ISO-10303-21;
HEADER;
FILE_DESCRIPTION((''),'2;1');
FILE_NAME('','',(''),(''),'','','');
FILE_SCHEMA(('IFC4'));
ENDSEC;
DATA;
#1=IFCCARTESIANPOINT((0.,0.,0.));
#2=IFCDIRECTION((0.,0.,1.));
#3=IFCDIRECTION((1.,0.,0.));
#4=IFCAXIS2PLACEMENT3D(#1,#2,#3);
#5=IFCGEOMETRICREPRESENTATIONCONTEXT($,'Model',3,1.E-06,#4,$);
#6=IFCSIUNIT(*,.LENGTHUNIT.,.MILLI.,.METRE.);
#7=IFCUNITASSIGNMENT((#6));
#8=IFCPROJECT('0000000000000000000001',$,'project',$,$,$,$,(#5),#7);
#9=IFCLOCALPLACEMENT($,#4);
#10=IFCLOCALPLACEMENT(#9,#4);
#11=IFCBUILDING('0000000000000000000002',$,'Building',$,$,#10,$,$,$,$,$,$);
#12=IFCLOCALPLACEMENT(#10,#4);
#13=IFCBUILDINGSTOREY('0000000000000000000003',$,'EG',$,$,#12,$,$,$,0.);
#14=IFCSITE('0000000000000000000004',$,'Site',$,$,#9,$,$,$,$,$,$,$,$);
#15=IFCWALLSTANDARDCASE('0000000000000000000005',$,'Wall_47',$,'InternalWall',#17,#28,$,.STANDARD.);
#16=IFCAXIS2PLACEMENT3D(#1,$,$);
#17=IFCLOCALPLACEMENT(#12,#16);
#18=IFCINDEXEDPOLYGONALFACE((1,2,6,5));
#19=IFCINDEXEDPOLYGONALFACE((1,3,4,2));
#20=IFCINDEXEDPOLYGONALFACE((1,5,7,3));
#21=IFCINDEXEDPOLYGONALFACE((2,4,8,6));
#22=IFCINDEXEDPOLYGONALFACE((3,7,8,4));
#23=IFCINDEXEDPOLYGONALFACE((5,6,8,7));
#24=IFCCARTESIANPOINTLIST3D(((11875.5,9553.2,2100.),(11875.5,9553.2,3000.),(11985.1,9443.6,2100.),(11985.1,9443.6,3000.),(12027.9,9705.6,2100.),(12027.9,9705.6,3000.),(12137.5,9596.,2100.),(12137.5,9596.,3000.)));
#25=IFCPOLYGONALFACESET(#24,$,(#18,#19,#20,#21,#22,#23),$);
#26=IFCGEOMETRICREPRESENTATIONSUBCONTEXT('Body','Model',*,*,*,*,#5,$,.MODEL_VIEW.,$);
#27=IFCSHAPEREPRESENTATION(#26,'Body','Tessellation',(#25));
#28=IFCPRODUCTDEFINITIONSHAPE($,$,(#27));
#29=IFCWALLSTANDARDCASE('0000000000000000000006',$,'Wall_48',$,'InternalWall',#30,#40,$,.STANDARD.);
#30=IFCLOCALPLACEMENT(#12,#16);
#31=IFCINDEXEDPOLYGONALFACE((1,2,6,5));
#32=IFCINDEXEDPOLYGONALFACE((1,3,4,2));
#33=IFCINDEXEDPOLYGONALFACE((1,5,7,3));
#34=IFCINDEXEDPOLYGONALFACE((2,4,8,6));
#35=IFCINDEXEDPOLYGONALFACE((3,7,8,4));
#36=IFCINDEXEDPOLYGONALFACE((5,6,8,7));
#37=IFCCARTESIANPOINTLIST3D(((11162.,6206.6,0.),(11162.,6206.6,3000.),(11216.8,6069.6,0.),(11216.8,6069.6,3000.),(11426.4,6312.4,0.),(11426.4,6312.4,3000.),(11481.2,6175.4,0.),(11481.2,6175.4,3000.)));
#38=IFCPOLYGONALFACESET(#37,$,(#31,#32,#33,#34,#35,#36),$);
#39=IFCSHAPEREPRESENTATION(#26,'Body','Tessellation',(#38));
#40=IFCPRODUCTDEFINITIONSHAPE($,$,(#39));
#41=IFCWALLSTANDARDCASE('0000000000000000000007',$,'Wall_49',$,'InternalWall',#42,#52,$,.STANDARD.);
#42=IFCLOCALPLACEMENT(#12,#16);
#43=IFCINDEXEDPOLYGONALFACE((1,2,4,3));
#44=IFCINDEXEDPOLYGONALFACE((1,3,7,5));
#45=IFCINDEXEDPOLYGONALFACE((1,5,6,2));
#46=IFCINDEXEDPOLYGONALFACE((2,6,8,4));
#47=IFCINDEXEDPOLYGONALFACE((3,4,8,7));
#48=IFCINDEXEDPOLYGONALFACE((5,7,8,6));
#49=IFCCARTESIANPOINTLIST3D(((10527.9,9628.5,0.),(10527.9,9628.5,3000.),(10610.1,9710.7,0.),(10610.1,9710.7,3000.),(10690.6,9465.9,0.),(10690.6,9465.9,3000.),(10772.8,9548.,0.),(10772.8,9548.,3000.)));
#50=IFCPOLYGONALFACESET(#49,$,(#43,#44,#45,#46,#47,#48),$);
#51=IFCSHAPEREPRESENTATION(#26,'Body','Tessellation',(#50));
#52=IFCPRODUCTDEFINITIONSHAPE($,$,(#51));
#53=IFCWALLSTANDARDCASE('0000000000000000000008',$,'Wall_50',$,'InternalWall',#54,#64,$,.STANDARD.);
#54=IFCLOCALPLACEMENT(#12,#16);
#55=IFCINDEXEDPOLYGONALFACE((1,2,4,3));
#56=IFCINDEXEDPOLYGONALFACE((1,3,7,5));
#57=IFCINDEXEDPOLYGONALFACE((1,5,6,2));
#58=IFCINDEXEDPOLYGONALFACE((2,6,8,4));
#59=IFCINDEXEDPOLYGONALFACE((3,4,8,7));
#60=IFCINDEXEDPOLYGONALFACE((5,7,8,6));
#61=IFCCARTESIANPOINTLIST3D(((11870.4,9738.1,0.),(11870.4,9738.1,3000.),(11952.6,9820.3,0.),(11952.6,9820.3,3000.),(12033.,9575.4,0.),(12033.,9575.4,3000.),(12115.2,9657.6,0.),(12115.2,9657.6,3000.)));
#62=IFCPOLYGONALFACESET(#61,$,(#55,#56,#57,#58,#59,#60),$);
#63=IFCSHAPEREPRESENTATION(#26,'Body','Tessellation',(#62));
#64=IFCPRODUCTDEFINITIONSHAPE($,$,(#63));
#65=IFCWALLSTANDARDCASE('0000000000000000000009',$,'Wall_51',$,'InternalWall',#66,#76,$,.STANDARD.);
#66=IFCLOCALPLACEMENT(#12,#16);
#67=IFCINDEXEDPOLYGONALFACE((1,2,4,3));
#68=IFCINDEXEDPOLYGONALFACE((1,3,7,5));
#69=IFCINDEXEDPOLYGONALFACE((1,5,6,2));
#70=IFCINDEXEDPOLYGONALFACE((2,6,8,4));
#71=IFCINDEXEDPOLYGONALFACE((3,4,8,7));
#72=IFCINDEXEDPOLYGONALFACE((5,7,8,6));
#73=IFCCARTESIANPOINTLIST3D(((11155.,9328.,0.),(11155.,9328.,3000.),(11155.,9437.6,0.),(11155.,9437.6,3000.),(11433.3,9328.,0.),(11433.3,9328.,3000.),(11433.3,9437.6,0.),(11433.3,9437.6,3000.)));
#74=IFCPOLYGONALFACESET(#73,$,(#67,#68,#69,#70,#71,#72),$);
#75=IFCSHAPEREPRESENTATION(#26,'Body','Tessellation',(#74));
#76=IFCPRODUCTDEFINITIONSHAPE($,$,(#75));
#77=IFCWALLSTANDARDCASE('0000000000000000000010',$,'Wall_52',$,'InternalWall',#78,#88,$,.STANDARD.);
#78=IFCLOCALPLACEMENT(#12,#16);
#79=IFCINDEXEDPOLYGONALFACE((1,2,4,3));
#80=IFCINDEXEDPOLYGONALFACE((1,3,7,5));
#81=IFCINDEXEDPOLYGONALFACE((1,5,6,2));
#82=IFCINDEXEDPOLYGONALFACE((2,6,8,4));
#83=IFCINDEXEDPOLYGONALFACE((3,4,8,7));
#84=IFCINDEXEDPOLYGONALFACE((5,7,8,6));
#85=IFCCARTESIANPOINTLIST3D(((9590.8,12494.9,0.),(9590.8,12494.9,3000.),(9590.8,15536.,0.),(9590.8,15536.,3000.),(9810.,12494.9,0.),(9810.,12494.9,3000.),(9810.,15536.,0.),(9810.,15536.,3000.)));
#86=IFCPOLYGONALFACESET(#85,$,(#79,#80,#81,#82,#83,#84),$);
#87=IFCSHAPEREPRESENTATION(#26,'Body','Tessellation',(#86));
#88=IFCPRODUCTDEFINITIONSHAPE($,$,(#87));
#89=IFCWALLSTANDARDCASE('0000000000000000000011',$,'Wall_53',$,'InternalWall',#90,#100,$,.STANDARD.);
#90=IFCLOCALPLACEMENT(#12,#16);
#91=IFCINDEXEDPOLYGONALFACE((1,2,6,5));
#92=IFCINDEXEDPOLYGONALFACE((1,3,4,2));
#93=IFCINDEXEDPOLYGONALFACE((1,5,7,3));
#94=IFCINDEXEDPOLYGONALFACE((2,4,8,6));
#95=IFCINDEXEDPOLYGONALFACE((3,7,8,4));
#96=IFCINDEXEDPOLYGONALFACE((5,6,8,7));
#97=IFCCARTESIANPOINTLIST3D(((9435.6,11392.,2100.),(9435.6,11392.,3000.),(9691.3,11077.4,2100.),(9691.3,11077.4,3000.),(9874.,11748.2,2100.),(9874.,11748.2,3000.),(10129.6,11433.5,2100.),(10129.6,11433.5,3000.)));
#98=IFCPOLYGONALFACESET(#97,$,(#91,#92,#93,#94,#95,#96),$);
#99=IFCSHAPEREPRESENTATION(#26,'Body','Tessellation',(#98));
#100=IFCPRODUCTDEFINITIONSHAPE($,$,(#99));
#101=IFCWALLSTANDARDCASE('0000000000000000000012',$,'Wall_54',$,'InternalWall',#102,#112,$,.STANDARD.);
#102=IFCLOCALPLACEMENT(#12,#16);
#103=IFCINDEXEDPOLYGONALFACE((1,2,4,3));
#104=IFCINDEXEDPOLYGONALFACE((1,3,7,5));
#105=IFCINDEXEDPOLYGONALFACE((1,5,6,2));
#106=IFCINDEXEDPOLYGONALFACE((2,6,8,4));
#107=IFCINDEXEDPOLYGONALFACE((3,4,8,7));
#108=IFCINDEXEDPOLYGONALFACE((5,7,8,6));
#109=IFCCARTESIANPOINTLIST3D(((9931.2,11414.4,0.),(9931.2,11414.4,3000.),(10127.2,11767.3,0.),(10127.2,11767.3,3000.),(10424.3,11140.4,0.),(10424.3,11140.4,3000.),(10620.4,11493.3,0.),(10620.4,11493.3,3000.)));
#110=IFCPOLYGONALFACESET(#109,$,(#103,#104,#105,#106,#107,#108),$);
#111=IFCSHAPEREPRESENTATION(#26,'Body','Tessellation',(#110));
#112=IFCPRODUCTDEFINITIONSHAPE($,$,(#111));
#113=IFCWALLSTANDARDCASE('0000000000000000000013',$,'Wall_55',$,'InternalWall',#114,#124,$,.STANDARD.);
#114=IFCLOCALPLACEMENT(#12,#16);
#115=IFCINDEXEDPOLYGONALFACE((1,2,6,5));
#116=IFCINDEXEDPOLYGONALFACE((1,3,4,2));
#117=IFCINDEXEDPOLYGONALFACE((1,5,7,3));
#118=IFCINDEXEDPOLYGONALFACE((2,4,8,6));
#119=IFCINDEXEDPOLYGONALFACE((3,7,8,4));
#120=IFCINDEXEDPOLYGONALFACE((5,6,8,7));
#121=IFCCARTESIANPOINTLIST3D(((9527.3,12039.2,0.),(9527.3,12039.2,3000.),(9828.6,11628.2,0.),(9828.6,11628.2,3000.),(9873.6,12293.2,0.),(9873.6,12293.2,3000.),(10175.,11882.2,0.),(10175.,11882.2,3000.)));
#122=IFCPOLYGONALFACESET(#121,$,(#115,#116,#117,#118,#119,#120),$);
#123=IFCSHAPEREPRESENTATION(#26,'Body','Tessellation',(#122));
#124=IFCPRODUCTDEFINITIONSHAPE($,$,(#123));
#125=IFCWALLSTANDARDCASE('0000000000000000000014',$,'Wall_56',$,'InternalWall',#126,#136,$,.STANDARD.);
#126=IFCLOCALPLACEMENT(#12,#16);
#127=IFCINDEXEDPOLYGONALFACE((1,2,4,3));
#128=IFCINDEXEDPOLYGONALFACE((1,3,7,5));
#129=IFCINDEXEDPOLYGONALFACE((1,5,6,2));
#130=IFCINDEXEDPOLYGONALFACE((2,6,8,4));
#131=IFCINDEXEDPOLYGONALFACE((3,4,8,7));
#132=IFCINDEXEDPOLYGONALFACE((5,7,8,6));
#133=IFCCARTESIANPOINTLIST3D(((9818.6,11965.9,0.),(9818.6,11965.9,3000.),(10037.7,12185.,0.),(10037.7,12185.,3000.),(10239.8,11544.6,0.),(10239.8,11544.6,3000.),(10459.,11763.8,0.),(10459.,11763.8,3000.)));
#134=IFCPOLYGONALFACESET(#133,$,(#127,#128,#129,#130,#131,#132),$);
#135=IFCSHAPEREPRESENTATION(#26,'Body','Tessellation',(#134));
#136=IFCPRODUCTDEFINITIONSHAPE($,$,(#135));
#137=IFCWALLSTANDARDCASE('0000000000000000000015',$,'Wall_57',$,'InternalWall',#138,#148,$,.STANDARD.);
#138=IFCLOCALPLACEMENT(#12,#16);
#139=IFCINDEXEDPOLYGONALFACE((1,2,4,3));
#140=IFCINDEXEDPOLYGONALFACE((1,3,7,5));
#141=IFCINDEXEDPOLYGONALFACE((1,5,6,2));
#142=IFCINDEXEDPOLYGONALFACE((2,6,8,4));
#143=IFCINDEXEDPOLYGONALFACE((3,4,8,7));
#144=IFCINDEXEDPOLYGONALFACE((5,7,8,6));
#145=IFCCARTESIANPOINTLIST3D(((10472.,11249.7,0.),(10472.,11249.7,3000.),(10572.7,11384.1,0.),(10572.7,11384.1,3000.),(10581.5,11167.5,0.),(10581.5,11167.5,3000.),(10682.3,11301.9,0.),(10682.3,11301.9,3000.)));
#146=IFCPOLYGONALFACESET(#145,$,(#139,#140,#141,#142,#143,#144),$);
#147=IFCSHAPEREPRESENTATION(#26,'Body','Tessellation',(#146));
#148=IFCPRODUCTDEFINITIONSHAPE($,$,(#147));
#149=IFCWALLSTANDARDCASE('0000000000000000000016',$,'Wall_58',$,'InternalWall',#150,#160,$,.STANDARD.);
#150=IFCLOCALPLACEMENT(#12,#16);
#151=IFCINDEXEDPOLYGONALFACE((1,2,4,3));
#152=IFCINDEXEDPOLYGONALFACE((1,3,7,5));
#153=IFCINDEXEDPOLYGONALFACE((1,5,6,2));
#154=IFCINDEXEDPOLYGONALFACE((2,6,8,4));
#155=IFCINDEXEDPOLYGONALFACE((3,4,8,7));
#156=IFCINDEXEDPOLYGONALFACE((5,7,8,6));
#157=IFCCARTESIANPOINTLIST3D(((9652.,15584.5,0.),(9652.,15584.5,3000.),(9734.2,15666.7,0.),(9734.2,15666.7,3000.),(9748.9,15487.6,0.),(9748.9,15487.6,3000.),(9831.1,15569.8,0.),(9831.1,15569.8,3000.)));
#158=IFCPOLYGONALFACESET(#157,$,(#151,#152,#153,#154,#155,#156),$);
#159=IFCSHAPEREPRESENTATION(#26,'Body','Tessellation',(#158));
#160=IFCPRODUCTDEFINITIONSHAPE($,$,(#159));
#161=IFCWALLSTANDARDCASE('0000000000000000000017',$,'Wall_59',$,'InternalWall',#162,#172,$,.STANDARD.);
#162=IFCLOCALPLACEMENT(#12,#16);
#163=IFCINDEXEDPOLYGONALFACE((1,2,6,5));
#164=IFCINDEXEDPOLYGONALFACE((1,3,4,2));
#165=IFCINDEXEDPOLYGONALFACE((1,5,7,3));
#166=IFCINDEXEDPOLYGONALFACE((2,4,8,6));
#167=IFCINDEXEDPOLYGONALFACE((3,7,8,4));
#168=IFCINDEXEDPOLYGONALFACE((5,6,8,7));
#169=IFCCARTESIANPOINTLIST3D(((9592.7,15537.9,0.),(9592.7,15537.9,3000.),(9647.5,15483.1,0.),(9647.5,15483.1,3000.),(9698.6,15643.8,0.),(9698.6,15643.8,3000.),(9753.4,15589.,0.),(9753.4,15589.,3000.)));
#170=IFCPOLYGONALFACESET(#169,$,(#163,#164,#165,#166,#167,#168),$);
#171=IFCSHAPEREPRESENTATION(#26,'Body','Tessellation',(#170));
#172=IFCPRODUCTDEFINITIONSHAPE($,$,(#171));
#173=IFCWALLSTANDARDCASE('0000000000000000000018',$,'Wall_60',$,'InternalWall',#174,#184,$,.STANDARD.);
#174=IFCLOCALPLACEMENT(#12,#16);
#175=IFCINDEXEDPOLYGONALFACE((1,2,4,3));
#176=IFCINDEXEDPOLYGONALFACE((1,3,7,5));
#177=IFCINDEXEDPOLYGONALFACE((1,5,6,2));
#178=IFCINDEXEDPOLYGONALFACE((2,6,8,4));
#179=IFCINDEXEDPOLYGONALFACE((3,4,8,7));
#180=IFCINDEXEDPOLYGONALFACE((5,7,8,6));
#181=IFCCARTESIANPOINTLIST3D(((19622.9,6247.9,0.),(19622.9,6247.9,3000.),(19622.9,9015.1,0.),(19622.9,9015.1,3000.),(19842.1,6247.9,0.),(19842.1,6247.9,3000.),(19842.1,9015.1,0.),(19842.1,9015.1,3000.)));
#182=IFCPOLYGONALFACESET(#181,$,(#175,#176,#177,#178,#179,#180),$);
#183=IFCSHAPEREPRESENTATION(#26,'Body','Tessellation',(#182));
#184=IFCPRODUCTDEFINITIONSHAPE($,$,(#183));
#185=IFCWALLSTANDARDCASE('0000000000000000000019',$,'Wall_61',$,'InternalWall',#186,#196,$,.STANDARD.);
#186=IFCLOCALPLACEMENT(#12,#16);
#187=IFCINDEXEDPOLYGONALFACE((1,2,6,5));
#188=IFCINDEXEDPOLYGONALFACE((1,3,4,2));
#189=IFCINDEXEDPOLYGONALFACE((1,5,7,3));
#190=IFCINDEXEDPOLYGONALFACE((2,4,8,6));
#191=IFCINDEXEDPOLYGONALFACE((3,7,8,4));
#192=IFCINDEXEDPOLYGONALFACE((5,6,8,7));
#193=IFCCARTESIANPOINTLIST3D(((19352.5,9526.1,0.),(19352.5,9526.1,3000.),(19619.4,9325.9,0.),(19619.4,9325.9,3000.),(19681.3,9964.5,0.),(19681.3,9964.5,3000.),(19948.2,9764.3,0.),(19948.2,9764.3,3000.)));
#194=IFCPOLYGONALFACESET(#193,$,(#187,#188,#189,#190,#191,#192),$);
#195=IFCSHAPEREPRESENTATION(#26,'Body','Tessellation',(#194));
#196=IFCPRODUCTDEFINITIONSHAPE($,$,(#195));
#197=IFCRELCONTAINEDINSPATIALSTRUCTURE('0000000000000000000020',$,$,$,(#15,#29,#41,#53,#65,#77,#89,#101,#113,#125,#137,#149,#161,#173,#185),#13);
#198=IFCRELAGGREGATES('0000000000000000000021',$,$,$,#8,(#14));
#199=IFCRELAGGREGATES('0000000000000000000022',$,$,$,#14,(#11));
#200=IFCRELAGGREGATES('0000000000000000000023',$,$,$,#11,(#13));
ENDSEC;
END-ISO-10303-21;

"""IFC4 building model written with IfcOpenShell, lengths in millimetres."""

from ifc_helpers import new_model, si_unit, frame, origin_with_axes, place, context, subcontext, project, spatial, rectangle, extrude, element, save


model = new_model("IFC4")

# Units and contexts
model_context = context("Model", 3, precision=1e-06, world=origin_with_axes())
body_context = subcontext(model_context, "Body", "Model", "MODEL_VIEW")
ifc_project = project(units=[si_unit("LENGTHUNIT", "METRE", prefix="MILLI")], contexts=[model_context])

# Site, building, storey
site_placement = place(None, origin_with_axes())
site = spatial("IfcSite", under=ifc_project, at=site_placement, Name="Site")
building_placement = place(site_placement, origin_with_axes())
building = spatial("IfcBuilding", under=site, at=building_placement, Name="Building")
storey_placement = place(building_placement, origin_with_axes())
storey = spatial("IfcBuildingStorey", under=building, at=storey_placement, Name="EG", Elevation=0.0)

# Wall, opening
wall_1_placement = place(storey_placement, origin_with_axes())
wall_1 = element("IfcWallStandardCase", 1, at=wall_1_placement, inside=storey, Name="Wall_47", ObjectType="InternalWall", PredefinedType="STANDARD", context=body_context, shape_type="SweptSolid", body=[
    extrude(rectangle(XDim=155.0, YDim=215.5), frame((12006.5, 9574.6, 0.0), z_axis=(0.0, 0.0, 1.0), x_axis=(0.707107, -0.707107, 0.0)), (0.0, 0.0, 1.0), 3000.0),
])
opening_1_placement = place(wall_1_placement, origin_with_axes())
element("IfcOpeningElement", 2, at=opening_1_placement, inside=storey, cuts=wall_1, context=body_context, shape_type="SweptSolid", body=[
    extrude(rectangle(XDim=450.0, YDim=215.5), frame((12006.9, 9574.1, 0.0), z_axis=(0.0, 0.0, 1.0), x_axis=(0.707107, -0.707107, 0.0)), (0.0, 0.0, 1.0), 2100.0),
])

# Walls
wall_2_placement = place(storey_placement, origin_with_axes())
element("IfcWallStandardCase", 3, at=wall_2_placement, inside=storey, Name="Wall_48", ObjectType="InternalWall", PredefinedType="STANDARD", context=body_context, shape_type="SweptSolid", body=[
    extrude(rectangle(XDim=147.5, YDim=284.8), frame((11321.6, 6191.0, 0.0), z_axis=(0.0, 0.0, 1.0), x_axis=(-0.371391, 0.928477, 0.0)), (0.0, 0.0, 1.0), 3000.0),
])
wall_3_placement = place(storey_placement, origin_with_axes())
element("IfcWallStandardCase", 4, at=wall_3_placement, inside=storey, Name="Wall_49", ObjectType="InternalWall", PredefinedType="STANDARD", context=body_context, shape_type="SweptSolid", body=[
    extrude(rectangle(XDim=116.2, YDim=230.0), frame((10650.3, 9588.3, 0.0), z_axis=(0.0, 0.0, 1.0), x_axis=(-0.707107, -0.707107, 0.0)), (0.0, 0.0, 1.0), 3000.0),
])
wall_4_placement = place(storey_placement, origin_with_axes())
element("IfcWallStandardCase", 5, at=wall_4_placement, inside=storey, Name="Wall_50", ObjectType="InternalWall", PredefinedType="STANDARD", context=body_context, shape_type="SweptSolid", body=[
    extrude(rectangle(XDim=116.2, YDim=230.0), frame((11992.8, 9697.9, 0.0), z_axis=(0.0, 0.0, 1.0), x_axis=(0.707107, 0.707107, 0.0)), (0.0, 0.0, 1.0), 3000.0),
])
wall_5_placement = place(storey_placement, origin_with_axes())
element("IfcWallStandardCase", 6, at=wall_5_placement, inside=storey, Name="Wall_51", ObjectType="InternalWall", PredefinedType="STANDARD", context=body_context, shape_type="SweptSolid", body=[
    extrude(rectangle(XDim=109.6, YDim=278.3), frame((11294.2, 9382.8, 0.0), z_axis=(0.0, 0.0, 1.0), x_axis=(0.0, 1.0, 0.0)), (0.0, 0.0, 1.0), 3000.0),
])
wall_6_placement = place(storey_placement, origin_with_axes())
element("IfcWallStandardCase", 7, at=wall_6_placement, inside=storey, Name="Wall_52", ObjectType="InternalWall", PredefinedType="STANDARD", context=body_context, shape_type="SweptSolid", body=[
    extrude(rectangle(XDim=3041.1, YDim=219.2), frame((9700.4, 14015.5, 0.0), z_axis=(0.0, 0.0, 1.0), x_axis=(0.0, 1.0, 0.0)), (0.0, 0.0, 1.0), 3000.0),
])

# Wall, opening
wall_7_placement = place(storey_placement, origin_with_axes())
wall_7 = element("IfcWallStandardCase", 8, at=wall_7_placement, inside=storey, Name="Wall_53", ObjectType="InternalWall", PredefinedType="STANDARD", context=body_context, shape_type="SweptSolid", body=[
    extrude(rectangle(XDim=564.8, YDim=405.4), frame((9782.6, 11412.8, 0.0), z_axis=(0.0, 0.0, 1.0), x_axis=(-0.776114, -0.630593, 0.0)), (0.0, 0.0, 1.0), 3000.0),
])
opening_2_placement = place(wall_7_placement, origin_with_axes())
element("IfcOpeningElement", 9, at=opening_2_placement, inside=storey, cuts=wall_7, context=body_context, shape_type="SweptSolid", body=[
    extrude(rectangle(XDim=564.8, YDim=405.4), frame((9782.6, 11412.8, 0.0), z_axis=(0.0, 0.0, 1.0), x_axis=(-0.776114, -0.630593, 0.0)), (0.0, 0.0, 1.0), 2100.0),
])

# Walls
wall_8_placement = place(storey_placement, origin_with_axes())
element("IfcWallStandardCase", 10, at=wall_8_placement, inside=storey, Name="Wall_54", ObjectType="InternalWall", PredefinedType="STANDARD", context=body_context, shape_type="SweptSolid", body=[
    extrude(rectangle(XDim=564.1, YDim=403.7), frame((10275.8, 11453.9, 0.0), z_axis=(0.0, 0.0, 1.0), x_axis=(0.874157, -0.485643, 0.0)), (0.0, 0.0, 1.0), 3000.0),
])
wall_9_placement = place(storey_placement, origin_with_axes())
element("IfcWallStandardCase", 11, at=wall_9_placement, inside=storey, Name="Wall_55", ObjectType="InternalWall", PredefinedType="STANDARD", context=body_context, shape_type="SweptSolid", body=[
    extrude(rectangle(XDim=509.6, YDim=429.5), frame((9851.1, 11960.7, 0.0), z_axis=(0.0, 0.0, 1.0), x_axis=(-0.591364, 0.806405, 0.0)), (0.0, 0.0, 1.0), 3000.0),
])
wall_10_placement = place(storey_placement, origin_with_axes())
element("IfcWallStandardCase", 12, at=wall_10_placement, inside=storey, Name="Wall_56", ObjectType="InternalWall", PredefinedType="STANDARD", context=body_context, shape_type="SweptSolid", body=[
    extrude(rectangle(XDim=310.0, YDim=595.8), frame((10138.8, 11864.8, 0.0), z_axis=(0.0, 0.0, 1.0), x_axis=(0.707107, 0.707107, 0.0)), (0.0, 0.0, 1.0), 3000.0),
])
wall_11_placement = place(storey_placement, origin_with_axes())
element("IfcWallStandardCase", 13, at=wall_11_placement, inside=storey, Name="Wall_57", ObjectType="InternalWall", PredefinedType="STANDARD", context=body_context, shape_type="SweptSolid", body=[
    extrude(rectangle(XDim=137.0, YDim=168.0), frame((10577.1, 11275.8, 0.0), z_axis=(0.0, 0.0, 1.0), x_axis=(0.8, -0.6, 0.0)), (0.0, 0.0, 1.0), 3000.0),
])
wall_12_placement = place(storey_placement, origin_with_axes())
element("IfcWallStandardCase", 14, at=wall_12_placement, inside=storey, Name="Wall_58", ObjectType="InternalWall", PredefinedType="STANDARD", context=body_context, shape_type="SweptSolid", body=[
    extrude(rectangle(XDim=116.2, YDim=137.0), frame((9741.5, 15577.1, 0.0), z_axis=(0.0, 0.0, 1.0), x_axis=(0.707107, 0.707107, 0.0)), (0.0, 0.0, 1.0), 3000.0),
])
wall_13_placement = place(storey_placement, origin_with_axes())
element("IfcWallStandardCase", 15, at=wall_13_placement, inside=storey, Name="Wall_59", ObjectType="InternalWall", PredefinedType="STANDARD", context=body_context, shape_type="SweptSolid", body=[
    extrude(rectangle(XDim=77.5, YDim=149.8), frame((9673.0, 15563.4, 0.0), z_axis=(0.0, 0.0, 1.0), x_axis=(-0.707107, 0.707107, 0.0)), (0.0, 0.0, 1.0), 3000.0),
])
wall_14_placement = place(storey_placement, origin_with_axes())
element("IfcWallStandardCase", 16, at=wall_14_placement, inside=storey, Name="Wall_60", ObjectType="InternalWall", PredefinedType="STANDARD", context=body_context, shape_type="SweptSolid", body=[
    extrude(rectangle(XDim=2767.1, YDim=219.2), frame((19732.5, 7631.5, 0.0), z_axis=(0.0, 0.0, 1.0), x_axis=(0.0, -1.0, 0.0)), (0.0, 0.0, 1.0), 3000.0),
])
wall_15_placement = place(storey_placement, origin_with_axes())
element("IfcWallStandardCase", 17, at=wall_15_placement, inside=storey, Name="Wall_61", ObjectType="InternalWall", PredefinedType="STANDARD", context=body_context, shape_type="SweptSolid", body=[
    extrude(rectangle(XDim=547.9, YDim=333.6), frame((19650.3, 9645.2, 0.0), z_axis=(0.0, 0.0, 1.0), x_axis=(0.6, 0.8, 0.0)), (0.0, 0.0, 1.0), 3000.0),
])

save(model, "model.ifc")
